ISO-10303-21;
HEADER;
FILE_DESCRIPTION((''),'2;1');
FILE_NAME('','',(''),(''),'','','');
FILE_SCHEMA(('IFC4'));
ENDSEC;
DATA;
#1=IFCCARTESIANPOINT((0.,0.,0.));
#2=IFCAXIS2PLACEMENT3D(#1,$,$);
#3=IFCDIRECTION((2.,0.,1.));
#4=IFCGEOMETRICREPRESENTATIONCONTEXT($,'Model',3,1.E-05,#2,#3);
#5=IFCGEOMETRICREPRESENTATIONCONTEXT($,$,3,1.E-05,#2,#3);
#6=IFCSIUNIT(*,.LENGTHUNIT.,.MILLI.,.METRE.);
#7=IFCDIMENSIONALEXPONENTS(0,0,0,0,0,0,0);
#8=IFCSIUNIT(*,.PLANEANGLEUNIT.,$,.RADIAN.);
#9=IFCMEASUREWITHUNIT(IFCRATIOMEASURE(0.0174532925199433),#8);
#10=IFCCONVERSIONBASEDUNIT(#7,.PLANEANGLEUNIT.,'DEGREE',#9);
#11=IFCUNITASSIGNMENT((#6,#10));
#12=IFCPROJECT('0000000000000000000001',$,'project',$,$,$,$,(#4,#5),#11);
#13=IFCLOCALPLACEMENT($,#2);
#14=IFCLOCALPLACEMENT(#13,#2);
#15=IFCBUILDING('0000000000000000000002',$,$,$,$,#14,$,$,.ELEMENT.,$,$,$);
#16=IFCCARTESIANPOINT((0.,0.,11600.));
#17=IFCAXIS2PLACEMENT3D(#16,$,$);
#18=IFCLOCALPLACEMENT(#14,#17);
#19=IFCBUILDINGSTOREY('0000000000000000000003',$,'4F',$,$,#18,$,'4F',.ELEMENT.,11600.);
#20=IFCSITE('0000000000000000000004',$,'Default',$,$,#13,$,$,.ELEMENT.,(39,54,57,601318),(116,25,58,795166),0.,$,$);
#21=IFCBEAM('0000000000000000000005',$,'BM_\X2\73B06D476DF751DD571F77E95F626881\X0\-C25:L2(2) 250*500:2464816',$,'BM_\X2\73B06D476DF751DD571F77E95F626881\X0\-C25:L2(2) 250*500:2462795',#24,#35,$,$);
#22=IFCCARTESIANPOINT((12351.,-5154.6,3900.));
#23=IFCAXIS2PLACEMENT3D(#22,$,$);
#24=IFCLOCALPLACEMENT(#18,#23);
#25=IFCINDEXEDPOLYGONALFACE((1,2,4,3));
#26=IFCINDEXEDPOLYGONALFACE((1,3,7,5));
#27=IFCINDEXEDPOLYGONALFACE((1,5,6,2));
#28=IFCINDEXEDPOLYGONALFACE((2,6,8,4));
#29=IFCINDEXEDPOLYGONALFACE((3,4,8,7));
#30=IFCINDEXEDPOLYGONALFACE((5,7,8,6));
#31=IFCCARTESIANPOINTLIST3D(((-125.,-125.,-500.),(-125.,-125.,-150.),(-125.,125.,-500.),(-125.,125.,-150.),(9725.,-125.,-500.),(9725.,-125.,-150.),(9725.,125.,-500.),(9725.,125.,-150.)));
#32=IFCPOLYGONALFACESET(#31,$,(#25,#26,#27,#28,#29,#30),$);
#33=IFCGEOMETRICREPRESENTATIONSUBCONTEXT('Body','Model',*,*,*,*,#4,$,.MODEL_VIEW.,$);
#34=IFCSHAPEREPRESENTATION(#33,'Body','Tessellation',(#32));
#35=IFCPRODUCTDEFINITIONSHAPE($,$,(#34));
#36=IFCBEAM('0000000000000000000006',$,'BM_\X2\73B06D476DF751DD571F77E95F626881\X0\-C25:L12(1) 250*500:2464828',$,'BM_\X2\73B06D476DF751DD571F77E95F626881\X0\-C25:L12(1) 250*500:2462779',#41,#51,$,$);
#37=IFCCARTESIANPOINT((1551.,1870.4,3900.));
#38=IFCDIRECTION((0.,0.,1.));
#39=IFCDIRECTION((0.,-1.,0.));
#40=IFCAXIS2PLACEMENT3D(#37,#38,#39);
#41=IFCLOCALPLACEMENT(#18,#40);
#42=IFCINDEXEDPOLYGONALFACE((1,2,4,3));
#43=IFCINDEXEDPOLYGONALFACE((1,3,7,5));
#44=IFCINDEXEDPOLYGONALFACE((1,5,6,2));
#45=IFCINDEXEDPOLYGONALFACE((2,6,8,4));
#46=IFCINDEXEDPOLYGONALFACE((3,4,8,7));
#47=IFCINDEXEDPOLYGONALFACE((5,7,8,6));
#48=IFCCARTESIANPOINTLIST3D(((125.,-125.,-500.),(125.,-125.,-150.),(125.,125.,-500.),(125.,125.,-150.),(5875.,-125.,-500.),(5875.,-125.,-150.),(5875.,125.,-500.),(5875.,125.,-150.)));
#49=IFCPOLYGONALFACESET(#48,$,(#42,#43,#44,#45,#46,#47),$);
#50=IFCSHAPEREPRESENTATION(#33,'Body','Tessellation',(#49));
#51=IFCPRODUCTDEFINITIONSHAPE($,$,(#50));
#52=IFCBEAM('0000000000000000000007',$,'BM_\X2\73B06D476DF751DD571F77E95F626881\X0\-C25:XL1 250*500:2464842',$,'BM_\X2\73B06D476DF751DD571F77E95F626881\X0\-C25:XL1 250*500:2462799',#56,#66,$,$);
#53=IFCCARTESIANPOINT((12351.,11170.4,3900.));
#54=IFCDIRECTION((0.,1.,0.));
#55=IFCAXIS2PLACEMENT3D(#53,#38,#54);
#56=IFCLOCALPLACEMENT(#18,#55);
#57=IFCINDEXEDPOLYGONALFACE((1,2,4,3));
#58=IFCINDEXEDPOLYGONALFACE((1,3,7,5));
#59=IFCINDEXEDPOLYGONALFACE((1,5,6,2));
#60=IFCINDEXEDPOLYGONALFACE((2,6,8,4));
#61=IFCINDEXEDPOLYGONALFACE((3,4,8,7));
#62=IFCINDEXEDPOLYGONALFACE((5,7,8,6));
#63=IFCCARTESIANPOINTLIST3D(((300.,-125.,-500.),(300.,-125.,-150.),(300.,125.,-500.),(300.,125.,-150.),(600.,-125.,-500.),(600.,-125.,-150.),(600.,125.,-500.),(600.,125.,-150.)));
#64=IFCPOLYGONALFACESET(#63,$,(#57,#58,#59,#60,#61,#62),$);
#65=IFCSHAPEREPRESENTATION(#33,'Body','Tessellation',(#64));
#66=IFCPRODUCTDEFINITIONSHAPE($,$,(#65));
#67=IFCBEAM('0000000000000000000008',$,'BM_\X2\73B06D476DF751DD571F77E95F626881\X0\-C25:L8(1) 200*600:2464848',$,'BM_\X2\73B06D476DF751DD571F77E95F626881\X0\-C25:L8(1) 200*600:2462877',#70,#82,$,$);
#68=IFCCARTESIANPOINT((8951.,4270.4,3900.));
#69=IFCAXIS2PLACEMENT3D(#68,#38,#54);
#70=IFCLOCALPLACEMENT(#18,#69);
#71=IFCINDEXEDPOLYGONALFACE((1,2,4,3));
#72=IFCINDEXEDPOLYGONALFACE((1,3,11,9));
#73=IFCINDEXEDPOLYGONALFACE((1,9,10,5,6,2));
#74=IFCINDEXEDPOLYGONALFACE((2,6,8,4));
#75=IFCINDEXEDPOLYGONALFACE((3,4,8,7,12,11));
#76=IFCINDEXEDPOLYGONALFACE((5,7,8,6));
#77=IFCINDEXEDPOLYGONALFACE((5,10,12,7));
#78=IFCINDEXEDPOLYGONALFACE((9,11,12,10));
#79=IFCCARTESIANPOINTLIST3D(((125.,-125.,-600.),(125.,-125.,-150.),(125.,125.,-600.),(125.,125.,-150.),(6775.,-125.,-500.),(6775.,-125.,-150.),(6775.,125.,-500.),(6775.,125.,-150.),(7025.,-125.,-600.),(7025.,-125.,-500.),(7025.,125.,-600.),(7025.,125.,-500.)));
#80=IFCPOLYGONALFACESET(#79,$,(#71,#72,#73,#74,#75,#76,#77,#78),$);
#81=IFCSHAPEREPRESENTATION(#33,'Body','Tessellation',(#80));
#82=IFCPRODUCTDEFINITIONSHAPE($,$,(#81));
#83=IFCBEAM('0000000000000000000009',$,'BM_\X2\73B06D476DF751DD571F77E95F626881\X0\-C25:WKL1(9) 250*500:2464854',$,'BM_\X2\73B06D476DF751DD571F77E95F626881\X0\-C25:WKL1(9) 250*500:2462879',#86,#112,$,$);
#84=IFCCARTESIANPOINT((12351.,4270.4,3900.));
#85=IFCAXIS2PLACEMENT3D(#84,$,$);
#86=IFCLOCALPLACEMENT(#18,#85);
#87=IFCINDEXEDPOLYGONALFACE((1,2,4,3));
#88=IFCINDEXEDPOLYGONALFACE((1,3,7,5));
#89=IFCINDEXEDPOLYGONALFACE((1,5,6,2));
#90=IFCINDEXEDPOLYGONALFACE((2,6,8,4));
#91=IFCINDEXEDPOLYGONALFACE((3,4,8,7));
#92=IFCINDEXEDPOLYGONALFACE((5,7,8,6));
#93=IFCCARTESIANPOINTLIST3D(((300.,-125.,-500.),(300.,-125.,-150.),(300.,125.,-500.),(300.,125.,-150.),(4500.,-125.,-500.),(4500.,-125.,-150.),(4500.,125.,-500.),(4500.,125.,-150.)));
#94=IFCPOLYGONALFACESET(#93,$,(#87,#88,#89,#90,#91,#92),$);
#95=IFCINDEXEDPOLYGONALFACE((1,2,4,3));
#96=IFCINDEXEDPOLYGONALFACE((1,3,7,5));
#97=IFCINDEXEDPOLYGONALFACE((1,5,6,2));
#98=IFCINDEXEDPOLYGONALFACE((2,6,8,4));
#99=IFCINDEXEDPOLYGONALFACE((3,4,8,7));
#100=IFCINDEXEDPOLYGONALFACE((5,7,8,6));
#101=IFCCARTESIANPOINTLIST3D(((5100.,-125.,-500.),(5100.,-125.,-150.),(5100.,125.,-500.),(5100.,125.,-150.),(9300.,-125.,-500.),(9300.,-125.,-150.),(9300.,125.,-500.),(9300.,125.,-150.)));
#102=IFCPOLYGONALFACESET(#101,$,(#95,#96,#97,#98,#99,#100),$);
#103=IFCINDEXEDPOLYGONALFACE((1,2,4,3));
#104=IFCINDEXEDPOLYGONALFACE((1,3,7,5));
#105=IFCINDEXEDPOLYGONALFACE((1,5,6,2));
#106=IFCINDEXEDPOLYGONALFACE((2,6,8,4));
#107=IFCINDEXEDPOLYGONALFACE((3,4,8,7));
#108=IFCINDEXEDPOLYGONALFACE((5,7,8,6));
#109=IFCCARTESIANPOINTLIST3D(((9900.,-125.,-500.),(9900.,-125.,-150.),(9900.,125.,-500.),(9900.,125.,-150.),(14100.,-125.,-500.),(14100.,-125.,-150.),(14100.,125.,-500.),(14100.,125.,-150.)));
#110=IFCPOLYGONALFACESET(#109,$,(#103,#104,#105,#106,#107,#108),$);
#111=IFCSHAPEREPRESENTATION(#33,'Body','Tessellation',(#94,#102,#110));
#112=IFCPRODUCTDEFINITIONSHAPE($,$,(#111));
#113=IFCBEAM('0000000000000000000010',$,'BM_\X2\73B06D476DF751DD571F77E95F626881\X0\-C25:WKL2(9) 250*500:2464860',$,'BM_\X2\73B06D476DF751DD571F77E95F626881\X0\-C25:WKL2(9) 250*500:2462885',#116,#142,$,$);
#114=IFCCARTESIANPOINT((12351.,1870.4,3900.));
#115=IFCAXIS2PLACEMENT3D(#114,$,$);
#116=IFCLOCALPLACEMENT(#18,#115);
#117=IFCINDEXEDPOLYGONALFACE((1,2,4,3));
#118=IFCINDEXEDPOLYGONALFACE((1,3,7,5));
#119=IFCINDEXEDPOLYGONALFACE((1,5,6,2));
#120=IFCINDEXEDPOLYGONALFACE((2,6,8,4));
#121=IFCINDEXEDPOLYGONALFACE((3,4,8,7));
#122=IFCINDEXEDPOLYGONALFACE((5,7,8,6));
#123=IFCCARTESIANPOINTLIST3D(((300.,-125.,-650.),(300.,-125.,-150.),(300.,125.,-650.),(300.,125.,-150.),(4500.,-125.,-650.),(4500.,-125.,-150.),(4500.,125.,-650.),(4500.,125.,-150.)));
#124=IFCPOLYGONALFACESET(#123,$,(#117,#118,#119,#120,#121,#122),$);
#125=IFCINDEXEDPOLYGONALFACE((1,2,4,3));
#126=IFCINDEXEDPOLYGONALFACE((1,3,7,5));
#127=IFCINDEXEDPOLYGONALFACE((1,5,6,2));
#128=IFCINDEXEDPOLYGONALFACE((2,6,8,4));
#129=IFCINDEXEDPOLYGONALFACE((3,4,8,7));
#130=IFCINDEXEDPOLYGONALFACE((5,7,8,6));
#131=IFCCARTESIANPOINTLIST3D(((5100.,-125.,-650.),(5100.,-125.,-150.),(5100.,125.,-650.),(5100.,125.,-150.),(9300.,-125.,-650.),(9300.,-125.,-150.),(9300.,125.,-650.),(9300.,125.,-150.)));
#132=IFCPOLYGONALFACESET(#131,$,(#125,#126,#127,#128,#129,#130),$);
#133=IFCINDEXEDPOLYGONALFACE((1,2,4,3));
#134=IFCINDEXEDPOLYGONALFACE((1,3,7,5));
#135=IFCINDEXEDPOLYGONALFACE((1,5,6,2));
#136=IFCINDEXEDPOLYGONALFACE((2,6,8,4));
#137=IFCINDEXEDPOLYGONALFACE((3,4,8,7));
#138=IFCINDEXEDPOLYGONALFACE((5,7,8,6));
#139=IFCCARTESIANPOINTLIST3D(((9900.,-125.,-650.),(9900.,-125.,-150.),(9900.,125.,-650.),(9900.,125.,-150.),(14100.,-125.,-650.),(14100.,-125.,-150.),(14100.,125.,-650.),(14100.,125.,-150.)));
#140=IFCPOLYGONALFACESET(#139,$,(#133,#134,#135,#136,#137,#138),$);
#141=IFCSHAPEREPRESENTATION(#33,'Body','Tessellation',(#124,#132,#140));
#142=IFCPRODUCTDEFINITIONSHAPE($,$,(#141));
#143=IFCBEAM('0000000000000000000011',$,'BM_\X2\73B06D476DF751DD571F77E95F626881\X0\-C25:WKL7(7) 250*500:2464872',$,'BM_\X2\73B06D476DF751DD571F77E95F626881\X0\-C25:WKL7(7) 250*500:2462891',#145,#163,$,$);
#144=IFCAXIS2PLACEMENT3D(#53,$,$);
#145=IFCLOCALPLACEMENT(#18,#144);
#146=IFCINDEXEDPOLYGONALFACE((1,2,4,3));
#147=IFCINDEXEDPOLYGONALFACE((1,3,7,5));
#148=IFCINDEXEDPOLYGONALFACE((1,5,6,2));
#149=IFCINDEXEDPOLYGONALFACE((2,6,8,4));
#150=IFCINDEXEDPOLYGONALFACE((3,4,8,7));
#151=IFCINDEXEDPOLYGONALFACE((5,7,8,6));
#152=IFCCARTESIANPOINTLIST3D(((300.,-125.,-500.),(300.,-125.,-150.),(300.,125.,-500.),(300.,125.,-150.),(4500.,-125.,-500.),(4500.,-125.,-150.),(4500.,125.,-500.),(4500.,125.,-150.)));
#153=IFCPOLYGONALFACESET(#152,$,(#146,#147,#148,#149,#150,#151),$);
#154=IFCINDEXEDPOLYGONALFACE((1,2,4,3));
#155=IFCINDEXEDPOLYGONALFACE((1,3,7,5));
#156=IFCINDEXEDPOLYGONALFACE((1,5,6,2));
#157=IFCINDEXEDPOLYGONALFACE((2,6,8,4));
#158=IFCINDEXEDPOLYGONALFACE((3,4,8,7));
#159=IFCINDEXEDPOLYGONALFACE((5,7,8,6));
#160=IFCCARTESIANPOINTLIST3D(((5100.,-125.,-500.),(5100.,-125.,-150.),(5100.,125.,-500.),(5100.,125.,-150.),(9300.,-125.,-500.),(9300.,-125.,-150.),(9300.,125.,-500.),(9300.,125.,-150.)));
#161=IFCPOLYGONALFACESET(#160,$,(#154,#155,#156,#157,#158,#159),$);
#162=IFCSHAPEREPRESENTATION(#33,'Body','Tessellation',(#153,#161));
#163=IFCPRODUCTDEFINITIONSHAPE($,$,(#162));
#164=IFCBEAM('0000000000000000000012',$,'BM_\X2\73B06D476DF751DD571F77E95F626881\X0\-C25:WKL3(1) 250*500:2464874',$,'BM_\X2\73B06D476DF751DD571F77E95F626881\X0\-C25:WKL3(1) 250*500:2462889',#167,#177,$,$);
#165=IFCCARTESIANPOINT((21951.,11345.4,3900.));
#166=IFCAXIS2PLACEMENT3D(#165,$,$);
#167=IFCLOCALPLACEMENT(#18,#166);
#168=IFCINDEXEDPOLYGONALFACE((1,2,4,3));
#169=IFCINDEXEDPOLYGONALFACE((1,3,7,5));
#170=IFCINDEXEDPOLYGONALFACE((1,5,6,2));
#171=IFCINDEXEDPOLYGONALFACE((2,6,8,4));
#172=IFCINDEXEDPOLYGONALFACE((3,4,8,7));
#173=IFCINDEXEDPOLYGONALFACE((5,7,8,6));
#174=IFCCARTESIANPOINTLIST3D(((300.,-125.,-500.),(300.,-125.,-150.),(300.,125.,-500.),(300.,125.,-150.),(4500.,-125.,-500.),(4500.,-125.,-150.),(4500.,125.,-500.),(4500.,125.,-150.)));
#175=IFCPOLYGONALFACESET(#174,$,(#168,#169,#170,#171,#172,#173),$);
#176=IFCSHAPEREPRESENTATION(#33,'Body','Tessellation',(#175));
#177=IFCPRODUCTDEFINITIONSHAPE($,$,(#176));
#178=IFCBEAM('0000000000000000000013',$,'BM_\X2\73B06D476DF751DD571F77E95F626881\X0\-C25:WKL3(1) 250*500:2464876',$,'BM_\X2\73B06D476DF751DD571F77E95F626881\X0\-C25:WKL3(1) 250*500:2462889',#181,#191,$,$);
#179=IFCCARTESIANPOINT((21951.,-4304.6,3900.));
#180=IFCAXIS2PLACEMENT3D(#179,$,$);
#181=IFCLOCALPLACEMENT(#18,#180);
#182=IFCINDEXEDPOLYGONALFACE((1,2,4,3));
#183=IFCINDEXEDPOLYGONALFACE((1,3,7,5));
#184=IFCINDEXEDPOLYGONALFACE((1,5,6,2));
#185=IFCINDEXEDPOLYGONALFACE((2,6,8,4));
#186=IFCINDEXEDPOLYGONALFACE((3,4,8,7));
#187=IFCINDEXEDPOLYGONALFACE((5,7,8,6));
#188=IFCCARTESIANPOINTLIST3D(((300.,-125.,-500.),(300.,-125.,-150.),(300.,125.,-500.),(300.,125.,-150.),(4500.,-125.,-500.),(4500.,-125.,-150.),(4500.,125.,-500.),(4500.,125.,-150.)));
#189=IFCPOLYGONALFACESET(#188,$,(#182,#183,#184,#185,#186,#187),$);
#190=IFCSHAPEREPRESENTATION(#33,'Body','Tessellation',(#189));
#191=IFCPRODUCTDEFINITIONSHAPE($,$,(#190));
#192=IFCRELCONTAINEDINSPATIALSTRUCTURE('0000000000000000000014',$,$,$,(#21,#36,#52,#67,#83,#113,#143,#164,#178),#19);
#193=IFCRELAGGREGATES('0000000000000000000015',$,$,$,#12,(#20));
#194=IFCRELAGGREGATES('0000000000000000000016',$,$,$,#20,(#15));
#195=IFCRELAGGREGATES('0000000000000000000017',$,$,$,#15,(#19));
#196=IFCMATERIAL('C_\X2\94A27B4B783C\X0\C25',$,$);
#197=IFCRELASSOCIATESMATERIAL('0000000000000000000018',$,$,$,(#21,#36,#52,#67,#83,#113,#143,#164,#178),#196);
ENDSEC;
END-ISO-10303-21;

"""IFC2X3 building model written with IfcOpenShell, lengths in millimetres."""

from ifc_helpers import new_model, entity, si_unit, converted_unit, direction, frame, frame_2d, origin, origin_2d_with_axis, place, context, subcontext, project, spatial, polyline, rectangle, extrude, clip, bounded_halfspace, material, element, save


model = new_model("IFC2X3")

# Units and contexts
model_context = context("Model", 3, precision=1e-05, world=origin(), true_north=direction((2.0, 0.0, 1.0)))
context_of_model = context(None, 3, precision=1e-05, world=origin(), true_north=direction((2.0, 0.0, 1.0)))
body_context = subcontext(model_context, "Body", "Model", "MODEL_VIEW")
ifc_project = project(units=[si_unit("LENGTHUNIT", "METRE", prefix="MILLI"), converted_unit("PLANEANGLEUNIT", "DEGREE", entity("IfcRatioMeasure", 0.0174532925199433), si_unit("PLANEANGLEUNIT", "RADIAN"), dimensions=[0, 0, 0, 0, 0, 0, 0])], contexts=[model_context, context_of_model])

# Site, building, storey
site_placement = place(None, origin())
site = spatial("IfcSite", under=ifc_project, at=site_placement, Name="Default", CompositionType="ELEMENT", RefLatitude=(39, 54, 57, 601318), RefLongitude=(116, 25, 58, 795166), RefElevation=0.0)
building_placement = place(site_placement, origin())
building = spatial("IfcBuilding", under=site, at=building_placement, CompositionType="ELEMENT")
storey_placement = place(building_placement, frame((0.0, 0.0, 11600.0)))
storey = spatial("IfcBuildingStorey", under=building, at=storey_placement, Name="4F", LongName="4F", CompositionType="ELEMENT", Elevation=11600.0)

# Shared definitions
ifc_material = material(Name="C_钢筋砼C25")

# Beams
beam_1_placement = place(storey_placement, frame((12351.0, -5154.6, 3900.0)))
element("IfcBeam", 1, at=beam_1_placement, inside=storey, material=ifc_material, Name="BM_现浇混凝土矩形梁-C25:L2(2) 250*500:2464816", ObjectType="BM_现浇混凝土矩形梁-C25:L2(2) 250*500:2462795", context=body_context, shape_type="SweptSolid", body=[
    extrude(rectangle(XDim=350.0, YDim=250.0, at=frame_2d((0.0, 0.0), x_axis=(1.0, 0.0))), frame((-125.0, 0.0, -325.0), z_axis=(1.0, 0.0, 0.0), x_axis=(0.0, 0.0, -1.0)), (0.0, 0.0, 1.0), 9850.0),
])
beam_2_placement = place(storey_placement, frame((1551.0, 1870.4, 3900.0), z_axis=(0.0, 0.0, 1.0), x_axis=(0.0, -1.0, 0.0)))
element("IfcBeam", 2, at=beam_2_placement, inside=storey, material=ifc_material, Name="BM_现浇混凝土矩形梁-C25:L12(1) 250*500:2464828", ObjectType="BM_现浇混凝土矩形梁-C25:L12(1) 250*500:2462779", context=body_context, shape_type="SweptSolid", body=[
    extrude(rectangle(XDim=350.0, YDim=250.0, at=frame_2d((0.0, 0.0), x_axis=(1.0, 0.0))), frame((125.0, 0.0, -325.0), z_axis=(1.0, 0.0, 0.0), x_axis=(0.0, 0.0, -1.0)), (0.0, 0.0, 1.0), 5750.0),
])
beam_3_placement = place(storey_placement, frame((12351.0, 11170.4, 3900.0), z_axis=(0.0, 0.0, 1.0), x_axis=(0.0, 1.0, 0.0)))
element("IfcBeam", 3, at=beam_3_placement, inside=storey, material=ifc_material, Name="BM_现浇混凝土矩形梁-C25:XL1 250*500:2464842", ObjectType="BM_现浇混凝土矩形梁-C25:XL1 250*500:2462799", context=body_context, shape_type="SweptSolid", body=[
    extrude(rectangle(XDim=350.0, YDim=250.0, at=frame_2d((0.0, 0.0), x_axis=(1.0, 0.0))), frame((300.0, 0.0, -325.0), z_axis=(1.0, 0.0, 0.0), x_axis=(0.0, 0.0, -1.0)), (0.0, 0.0, 1.0), 300.0),
])
beam_4_placement = place(storey_placement, frame((8951.0, 4270.4, 3900.0), z_axis=(0.0, 0.0, 1.0), x_axis=(0.0, 1.0, 0.0)))
element("IfcBeam", 4, at=beam_4_placement, inside=storey, material=ifc_material, Name="BM_现浇混凝土矩形梁-C25:L8(1) 200*600:2464848", ObjectType="BM_现浇混凝土矩形梁-C25:L8(1) 200*600:2462877", context=body_context, shape_type="Clipping", body=[
    clip(extrude(rectangle(XDim=450.0, YDim=250.0, at=frame_2d((0.0, 0.0), x_axis=(0.0, 1.0))), frame((125.0, 0.0, -375.0), z_axis=(1.0, 0.0, 0.0), x_axis=(0.0, 1.0, 0.0)), (0.0, 0.0, 1.0), 6900.0), bounded_halfspace(frame((6775.0, 17887.3, -500.0), z_axis=(1.0, 0.0, 0.0), x_axis=(0.0, 0.0, 1.0)), False, frame((125.0, 0.0, -375.0), z_axis=(1.0, 0.0, 0.0), x_axis=(0.0, 1.0, 0.0)), polyline([(-125.0, -125.0), (125.0, -125.0), (125.0, 225.0), (-125.0, 225.0), (-125.0, -125.0)]))),
])
beam_5_placement = place(storey_placement, frame((12351.0, 4270.4, 3900.0)))
element("IfcBeam", 5, at=beam_5_placement, inside=storey, material=ifc_material, Name="BM_现浇混凝土矩形梁-C25:WKL1(9) 250*500:2464854", ObjectType="BM_现浇混凝土矩形梁-C25:WKL1(9) 250*500:2462879", context=body_context, shape_type="SweptSolid", body=[
    extrude(rectangle(XDim=350.0, YDim=250.0, at=frame_2d((0.0, 0.0), x_axis=(1.0, 0.0))), frame((300.0, 0.0, -325.0), z_axis=(1.0, 0.0, 0.0), x_axis=(0.0, 0.0, 1.0)), (0.0, 0.0, 1.0), 4200.0),
    extrude(rectangle(XDim=350.0, YDim=250.0, at=origin_2d_with_axis()), frame((5100.0, 0.0, -325.0), z_axis=(1.0, 0.0, 0.0), x_axis=(0.0, 0.0, 1.0)), (0.0, 0.0, 1.0), 4200.0),
    extrude(rectangle(XDim=350.0, YDim=250.0, at=frame_2d((0.0, 0.0), x_axis=(1.0, 0.0))), frame((9900.0, 0.0, -325.0), z_axis=(1.0, 0.0, 0.0), x_axis=(0.0, 0.0, 1.0)), (0.0, 0.0, 1.0), 4200.0),
])
beam_6_placement = place(storey_placement, frame((12351.0, 1870.4, 3900.0)))
element("IfcBeam", 6, at=beam_6_placement, inside=storey, material=ifc_material, Name="BM_现浇混凝土矩形梁-C25:WKL2(9) 250*500:2464860", ObjectType="BM_现浇混凝土矩形梁-C25:WKL2(9) 250*500:2462885", context=body_context, shape_type="SweptSolid", body=[
    extrude(rectangle(XDim=500.0, YDim=250.0, at=frame_2d((0.0, 0.0), x_axis=(1.0, 0.0))), frame((300.0, 0.0, -400.0), z_axis=(1.0, 0.0, 0.0), x_axis=(0.0, 0.0, 1.0)), (0.0, 0.0, 1.0), 4200.0),
    extrude(rectangle(XDim=500.0, YDim=250.0, at=frame_2d((0.0, 0.0), x_axis=(1.0, 0.0))), frame((5100.0, 0.0, -400.0), z_axis=(1.0, 0.0, 0.0), x_axis=(0.0, 0.0, 1.0)), (0.0, 0.0, 1.0), 4200.0),
    extrude(rectangle(XDim=500.0, YDim=250.0, at=frame_2d((0.0, 0.0), x_axis=(1.0, 0.0))), frame((9900.0, 0.0, -400.0), z_axis=(1.0, 0.0, 0.0), x_axis=(0.0, 0.0, 1.0)), (0.0, 0.0, 1.0), 4200.0),
])
beam_7_placement = place(storey_placement, frame((12351.0, 11170.4, 3900.0)))
element("IfcBeam", 7, at=beam_7_placement, inside=storey, material=ifc_material, Name="BM_现浇混凝土矩形梁-C25:WKL7(7) 250*500:2464872", ObjectType="BM_现浇混凝土矩形梁-C25:WKL7(7) 250*500:2462891", context=body_context, shape_type="SweptSolid", body=[
    extrude(rectangle(XDim=350.0, YDim=250.0, at=origin_2d_with_axis()), frame((300.0, 0.0, -325.0), z_axis=(1.0, 0.0, 0.0), x_axis=(0.0, 0.0, 1.0)), (0.0, 0.0, 1.0), 4200.0),
    extrude(rectangle(XDim=350.0, YDim=250.0, at=origin_2d_with_axis()), frame((5100.0, 0.0, -325.0), z_axis=(1.0, 0.0, 0.0), x_axis=(0.0, 0.0, 1.0)), (0.0, 0.0, 1.0), 4200.0),
])
beam_8_placement = place(storey_placement, frame((21951.0, 11345.4, 3900.0)))
element("IfcBeam", 8, at=beam_8_placement, inside=storey, material=ifc_material, Name="BM_现浇混凝土矩形梁-C25:WKL3(1) 250*500:2464874", ObjectType="BM_现浇混凝土矩形梁-C25:WKL3(1) 250*500:2462889", context=body_context, shape_type="SweptSolid", body=[
    extrude(rectangle(XDim=350.0, YDim=250.0, at=frame_2d((0.0, 0.0), x_axis=(1.0, 0.0))), frame((300.0, 0.0, -325.0), z_axis=(1.0, 0.0, 0.0), x_axis=(0.0, 0.0, -1.0)), (0.0, 0.0, 1.0), 4200.0),
])
beam_9_placement = place(storey_placement, frame((21951.0, -4304.6, 3900.0)))
element("IfcBeam", 9, at=beam_9_placement, inside=storey, material=ifc_material, Name="BM_现浇混凝土矩形梁-C25:WKL3(1) 250*500:2464876", ObjectType="BM_现浇混凝土矩形梁-C25:WKL3(1) 250*500:2462889", context=body_context, shape_type="SweptSolid", body=[
    extrude(rectangle(XDim=350.0, YDim=250.0, at=frame_2d((0.0, 0.0), x_axis=(1.0, 0.0))), frame((300.0, 0.0, -325.0), z_axis=(1.0, 0.0, 0.0), x_axis=(0.0, 0.0, -1.0)), (0.0, 0.0, 1.0), 4200.0),
])

save(model, "model.ifc")
